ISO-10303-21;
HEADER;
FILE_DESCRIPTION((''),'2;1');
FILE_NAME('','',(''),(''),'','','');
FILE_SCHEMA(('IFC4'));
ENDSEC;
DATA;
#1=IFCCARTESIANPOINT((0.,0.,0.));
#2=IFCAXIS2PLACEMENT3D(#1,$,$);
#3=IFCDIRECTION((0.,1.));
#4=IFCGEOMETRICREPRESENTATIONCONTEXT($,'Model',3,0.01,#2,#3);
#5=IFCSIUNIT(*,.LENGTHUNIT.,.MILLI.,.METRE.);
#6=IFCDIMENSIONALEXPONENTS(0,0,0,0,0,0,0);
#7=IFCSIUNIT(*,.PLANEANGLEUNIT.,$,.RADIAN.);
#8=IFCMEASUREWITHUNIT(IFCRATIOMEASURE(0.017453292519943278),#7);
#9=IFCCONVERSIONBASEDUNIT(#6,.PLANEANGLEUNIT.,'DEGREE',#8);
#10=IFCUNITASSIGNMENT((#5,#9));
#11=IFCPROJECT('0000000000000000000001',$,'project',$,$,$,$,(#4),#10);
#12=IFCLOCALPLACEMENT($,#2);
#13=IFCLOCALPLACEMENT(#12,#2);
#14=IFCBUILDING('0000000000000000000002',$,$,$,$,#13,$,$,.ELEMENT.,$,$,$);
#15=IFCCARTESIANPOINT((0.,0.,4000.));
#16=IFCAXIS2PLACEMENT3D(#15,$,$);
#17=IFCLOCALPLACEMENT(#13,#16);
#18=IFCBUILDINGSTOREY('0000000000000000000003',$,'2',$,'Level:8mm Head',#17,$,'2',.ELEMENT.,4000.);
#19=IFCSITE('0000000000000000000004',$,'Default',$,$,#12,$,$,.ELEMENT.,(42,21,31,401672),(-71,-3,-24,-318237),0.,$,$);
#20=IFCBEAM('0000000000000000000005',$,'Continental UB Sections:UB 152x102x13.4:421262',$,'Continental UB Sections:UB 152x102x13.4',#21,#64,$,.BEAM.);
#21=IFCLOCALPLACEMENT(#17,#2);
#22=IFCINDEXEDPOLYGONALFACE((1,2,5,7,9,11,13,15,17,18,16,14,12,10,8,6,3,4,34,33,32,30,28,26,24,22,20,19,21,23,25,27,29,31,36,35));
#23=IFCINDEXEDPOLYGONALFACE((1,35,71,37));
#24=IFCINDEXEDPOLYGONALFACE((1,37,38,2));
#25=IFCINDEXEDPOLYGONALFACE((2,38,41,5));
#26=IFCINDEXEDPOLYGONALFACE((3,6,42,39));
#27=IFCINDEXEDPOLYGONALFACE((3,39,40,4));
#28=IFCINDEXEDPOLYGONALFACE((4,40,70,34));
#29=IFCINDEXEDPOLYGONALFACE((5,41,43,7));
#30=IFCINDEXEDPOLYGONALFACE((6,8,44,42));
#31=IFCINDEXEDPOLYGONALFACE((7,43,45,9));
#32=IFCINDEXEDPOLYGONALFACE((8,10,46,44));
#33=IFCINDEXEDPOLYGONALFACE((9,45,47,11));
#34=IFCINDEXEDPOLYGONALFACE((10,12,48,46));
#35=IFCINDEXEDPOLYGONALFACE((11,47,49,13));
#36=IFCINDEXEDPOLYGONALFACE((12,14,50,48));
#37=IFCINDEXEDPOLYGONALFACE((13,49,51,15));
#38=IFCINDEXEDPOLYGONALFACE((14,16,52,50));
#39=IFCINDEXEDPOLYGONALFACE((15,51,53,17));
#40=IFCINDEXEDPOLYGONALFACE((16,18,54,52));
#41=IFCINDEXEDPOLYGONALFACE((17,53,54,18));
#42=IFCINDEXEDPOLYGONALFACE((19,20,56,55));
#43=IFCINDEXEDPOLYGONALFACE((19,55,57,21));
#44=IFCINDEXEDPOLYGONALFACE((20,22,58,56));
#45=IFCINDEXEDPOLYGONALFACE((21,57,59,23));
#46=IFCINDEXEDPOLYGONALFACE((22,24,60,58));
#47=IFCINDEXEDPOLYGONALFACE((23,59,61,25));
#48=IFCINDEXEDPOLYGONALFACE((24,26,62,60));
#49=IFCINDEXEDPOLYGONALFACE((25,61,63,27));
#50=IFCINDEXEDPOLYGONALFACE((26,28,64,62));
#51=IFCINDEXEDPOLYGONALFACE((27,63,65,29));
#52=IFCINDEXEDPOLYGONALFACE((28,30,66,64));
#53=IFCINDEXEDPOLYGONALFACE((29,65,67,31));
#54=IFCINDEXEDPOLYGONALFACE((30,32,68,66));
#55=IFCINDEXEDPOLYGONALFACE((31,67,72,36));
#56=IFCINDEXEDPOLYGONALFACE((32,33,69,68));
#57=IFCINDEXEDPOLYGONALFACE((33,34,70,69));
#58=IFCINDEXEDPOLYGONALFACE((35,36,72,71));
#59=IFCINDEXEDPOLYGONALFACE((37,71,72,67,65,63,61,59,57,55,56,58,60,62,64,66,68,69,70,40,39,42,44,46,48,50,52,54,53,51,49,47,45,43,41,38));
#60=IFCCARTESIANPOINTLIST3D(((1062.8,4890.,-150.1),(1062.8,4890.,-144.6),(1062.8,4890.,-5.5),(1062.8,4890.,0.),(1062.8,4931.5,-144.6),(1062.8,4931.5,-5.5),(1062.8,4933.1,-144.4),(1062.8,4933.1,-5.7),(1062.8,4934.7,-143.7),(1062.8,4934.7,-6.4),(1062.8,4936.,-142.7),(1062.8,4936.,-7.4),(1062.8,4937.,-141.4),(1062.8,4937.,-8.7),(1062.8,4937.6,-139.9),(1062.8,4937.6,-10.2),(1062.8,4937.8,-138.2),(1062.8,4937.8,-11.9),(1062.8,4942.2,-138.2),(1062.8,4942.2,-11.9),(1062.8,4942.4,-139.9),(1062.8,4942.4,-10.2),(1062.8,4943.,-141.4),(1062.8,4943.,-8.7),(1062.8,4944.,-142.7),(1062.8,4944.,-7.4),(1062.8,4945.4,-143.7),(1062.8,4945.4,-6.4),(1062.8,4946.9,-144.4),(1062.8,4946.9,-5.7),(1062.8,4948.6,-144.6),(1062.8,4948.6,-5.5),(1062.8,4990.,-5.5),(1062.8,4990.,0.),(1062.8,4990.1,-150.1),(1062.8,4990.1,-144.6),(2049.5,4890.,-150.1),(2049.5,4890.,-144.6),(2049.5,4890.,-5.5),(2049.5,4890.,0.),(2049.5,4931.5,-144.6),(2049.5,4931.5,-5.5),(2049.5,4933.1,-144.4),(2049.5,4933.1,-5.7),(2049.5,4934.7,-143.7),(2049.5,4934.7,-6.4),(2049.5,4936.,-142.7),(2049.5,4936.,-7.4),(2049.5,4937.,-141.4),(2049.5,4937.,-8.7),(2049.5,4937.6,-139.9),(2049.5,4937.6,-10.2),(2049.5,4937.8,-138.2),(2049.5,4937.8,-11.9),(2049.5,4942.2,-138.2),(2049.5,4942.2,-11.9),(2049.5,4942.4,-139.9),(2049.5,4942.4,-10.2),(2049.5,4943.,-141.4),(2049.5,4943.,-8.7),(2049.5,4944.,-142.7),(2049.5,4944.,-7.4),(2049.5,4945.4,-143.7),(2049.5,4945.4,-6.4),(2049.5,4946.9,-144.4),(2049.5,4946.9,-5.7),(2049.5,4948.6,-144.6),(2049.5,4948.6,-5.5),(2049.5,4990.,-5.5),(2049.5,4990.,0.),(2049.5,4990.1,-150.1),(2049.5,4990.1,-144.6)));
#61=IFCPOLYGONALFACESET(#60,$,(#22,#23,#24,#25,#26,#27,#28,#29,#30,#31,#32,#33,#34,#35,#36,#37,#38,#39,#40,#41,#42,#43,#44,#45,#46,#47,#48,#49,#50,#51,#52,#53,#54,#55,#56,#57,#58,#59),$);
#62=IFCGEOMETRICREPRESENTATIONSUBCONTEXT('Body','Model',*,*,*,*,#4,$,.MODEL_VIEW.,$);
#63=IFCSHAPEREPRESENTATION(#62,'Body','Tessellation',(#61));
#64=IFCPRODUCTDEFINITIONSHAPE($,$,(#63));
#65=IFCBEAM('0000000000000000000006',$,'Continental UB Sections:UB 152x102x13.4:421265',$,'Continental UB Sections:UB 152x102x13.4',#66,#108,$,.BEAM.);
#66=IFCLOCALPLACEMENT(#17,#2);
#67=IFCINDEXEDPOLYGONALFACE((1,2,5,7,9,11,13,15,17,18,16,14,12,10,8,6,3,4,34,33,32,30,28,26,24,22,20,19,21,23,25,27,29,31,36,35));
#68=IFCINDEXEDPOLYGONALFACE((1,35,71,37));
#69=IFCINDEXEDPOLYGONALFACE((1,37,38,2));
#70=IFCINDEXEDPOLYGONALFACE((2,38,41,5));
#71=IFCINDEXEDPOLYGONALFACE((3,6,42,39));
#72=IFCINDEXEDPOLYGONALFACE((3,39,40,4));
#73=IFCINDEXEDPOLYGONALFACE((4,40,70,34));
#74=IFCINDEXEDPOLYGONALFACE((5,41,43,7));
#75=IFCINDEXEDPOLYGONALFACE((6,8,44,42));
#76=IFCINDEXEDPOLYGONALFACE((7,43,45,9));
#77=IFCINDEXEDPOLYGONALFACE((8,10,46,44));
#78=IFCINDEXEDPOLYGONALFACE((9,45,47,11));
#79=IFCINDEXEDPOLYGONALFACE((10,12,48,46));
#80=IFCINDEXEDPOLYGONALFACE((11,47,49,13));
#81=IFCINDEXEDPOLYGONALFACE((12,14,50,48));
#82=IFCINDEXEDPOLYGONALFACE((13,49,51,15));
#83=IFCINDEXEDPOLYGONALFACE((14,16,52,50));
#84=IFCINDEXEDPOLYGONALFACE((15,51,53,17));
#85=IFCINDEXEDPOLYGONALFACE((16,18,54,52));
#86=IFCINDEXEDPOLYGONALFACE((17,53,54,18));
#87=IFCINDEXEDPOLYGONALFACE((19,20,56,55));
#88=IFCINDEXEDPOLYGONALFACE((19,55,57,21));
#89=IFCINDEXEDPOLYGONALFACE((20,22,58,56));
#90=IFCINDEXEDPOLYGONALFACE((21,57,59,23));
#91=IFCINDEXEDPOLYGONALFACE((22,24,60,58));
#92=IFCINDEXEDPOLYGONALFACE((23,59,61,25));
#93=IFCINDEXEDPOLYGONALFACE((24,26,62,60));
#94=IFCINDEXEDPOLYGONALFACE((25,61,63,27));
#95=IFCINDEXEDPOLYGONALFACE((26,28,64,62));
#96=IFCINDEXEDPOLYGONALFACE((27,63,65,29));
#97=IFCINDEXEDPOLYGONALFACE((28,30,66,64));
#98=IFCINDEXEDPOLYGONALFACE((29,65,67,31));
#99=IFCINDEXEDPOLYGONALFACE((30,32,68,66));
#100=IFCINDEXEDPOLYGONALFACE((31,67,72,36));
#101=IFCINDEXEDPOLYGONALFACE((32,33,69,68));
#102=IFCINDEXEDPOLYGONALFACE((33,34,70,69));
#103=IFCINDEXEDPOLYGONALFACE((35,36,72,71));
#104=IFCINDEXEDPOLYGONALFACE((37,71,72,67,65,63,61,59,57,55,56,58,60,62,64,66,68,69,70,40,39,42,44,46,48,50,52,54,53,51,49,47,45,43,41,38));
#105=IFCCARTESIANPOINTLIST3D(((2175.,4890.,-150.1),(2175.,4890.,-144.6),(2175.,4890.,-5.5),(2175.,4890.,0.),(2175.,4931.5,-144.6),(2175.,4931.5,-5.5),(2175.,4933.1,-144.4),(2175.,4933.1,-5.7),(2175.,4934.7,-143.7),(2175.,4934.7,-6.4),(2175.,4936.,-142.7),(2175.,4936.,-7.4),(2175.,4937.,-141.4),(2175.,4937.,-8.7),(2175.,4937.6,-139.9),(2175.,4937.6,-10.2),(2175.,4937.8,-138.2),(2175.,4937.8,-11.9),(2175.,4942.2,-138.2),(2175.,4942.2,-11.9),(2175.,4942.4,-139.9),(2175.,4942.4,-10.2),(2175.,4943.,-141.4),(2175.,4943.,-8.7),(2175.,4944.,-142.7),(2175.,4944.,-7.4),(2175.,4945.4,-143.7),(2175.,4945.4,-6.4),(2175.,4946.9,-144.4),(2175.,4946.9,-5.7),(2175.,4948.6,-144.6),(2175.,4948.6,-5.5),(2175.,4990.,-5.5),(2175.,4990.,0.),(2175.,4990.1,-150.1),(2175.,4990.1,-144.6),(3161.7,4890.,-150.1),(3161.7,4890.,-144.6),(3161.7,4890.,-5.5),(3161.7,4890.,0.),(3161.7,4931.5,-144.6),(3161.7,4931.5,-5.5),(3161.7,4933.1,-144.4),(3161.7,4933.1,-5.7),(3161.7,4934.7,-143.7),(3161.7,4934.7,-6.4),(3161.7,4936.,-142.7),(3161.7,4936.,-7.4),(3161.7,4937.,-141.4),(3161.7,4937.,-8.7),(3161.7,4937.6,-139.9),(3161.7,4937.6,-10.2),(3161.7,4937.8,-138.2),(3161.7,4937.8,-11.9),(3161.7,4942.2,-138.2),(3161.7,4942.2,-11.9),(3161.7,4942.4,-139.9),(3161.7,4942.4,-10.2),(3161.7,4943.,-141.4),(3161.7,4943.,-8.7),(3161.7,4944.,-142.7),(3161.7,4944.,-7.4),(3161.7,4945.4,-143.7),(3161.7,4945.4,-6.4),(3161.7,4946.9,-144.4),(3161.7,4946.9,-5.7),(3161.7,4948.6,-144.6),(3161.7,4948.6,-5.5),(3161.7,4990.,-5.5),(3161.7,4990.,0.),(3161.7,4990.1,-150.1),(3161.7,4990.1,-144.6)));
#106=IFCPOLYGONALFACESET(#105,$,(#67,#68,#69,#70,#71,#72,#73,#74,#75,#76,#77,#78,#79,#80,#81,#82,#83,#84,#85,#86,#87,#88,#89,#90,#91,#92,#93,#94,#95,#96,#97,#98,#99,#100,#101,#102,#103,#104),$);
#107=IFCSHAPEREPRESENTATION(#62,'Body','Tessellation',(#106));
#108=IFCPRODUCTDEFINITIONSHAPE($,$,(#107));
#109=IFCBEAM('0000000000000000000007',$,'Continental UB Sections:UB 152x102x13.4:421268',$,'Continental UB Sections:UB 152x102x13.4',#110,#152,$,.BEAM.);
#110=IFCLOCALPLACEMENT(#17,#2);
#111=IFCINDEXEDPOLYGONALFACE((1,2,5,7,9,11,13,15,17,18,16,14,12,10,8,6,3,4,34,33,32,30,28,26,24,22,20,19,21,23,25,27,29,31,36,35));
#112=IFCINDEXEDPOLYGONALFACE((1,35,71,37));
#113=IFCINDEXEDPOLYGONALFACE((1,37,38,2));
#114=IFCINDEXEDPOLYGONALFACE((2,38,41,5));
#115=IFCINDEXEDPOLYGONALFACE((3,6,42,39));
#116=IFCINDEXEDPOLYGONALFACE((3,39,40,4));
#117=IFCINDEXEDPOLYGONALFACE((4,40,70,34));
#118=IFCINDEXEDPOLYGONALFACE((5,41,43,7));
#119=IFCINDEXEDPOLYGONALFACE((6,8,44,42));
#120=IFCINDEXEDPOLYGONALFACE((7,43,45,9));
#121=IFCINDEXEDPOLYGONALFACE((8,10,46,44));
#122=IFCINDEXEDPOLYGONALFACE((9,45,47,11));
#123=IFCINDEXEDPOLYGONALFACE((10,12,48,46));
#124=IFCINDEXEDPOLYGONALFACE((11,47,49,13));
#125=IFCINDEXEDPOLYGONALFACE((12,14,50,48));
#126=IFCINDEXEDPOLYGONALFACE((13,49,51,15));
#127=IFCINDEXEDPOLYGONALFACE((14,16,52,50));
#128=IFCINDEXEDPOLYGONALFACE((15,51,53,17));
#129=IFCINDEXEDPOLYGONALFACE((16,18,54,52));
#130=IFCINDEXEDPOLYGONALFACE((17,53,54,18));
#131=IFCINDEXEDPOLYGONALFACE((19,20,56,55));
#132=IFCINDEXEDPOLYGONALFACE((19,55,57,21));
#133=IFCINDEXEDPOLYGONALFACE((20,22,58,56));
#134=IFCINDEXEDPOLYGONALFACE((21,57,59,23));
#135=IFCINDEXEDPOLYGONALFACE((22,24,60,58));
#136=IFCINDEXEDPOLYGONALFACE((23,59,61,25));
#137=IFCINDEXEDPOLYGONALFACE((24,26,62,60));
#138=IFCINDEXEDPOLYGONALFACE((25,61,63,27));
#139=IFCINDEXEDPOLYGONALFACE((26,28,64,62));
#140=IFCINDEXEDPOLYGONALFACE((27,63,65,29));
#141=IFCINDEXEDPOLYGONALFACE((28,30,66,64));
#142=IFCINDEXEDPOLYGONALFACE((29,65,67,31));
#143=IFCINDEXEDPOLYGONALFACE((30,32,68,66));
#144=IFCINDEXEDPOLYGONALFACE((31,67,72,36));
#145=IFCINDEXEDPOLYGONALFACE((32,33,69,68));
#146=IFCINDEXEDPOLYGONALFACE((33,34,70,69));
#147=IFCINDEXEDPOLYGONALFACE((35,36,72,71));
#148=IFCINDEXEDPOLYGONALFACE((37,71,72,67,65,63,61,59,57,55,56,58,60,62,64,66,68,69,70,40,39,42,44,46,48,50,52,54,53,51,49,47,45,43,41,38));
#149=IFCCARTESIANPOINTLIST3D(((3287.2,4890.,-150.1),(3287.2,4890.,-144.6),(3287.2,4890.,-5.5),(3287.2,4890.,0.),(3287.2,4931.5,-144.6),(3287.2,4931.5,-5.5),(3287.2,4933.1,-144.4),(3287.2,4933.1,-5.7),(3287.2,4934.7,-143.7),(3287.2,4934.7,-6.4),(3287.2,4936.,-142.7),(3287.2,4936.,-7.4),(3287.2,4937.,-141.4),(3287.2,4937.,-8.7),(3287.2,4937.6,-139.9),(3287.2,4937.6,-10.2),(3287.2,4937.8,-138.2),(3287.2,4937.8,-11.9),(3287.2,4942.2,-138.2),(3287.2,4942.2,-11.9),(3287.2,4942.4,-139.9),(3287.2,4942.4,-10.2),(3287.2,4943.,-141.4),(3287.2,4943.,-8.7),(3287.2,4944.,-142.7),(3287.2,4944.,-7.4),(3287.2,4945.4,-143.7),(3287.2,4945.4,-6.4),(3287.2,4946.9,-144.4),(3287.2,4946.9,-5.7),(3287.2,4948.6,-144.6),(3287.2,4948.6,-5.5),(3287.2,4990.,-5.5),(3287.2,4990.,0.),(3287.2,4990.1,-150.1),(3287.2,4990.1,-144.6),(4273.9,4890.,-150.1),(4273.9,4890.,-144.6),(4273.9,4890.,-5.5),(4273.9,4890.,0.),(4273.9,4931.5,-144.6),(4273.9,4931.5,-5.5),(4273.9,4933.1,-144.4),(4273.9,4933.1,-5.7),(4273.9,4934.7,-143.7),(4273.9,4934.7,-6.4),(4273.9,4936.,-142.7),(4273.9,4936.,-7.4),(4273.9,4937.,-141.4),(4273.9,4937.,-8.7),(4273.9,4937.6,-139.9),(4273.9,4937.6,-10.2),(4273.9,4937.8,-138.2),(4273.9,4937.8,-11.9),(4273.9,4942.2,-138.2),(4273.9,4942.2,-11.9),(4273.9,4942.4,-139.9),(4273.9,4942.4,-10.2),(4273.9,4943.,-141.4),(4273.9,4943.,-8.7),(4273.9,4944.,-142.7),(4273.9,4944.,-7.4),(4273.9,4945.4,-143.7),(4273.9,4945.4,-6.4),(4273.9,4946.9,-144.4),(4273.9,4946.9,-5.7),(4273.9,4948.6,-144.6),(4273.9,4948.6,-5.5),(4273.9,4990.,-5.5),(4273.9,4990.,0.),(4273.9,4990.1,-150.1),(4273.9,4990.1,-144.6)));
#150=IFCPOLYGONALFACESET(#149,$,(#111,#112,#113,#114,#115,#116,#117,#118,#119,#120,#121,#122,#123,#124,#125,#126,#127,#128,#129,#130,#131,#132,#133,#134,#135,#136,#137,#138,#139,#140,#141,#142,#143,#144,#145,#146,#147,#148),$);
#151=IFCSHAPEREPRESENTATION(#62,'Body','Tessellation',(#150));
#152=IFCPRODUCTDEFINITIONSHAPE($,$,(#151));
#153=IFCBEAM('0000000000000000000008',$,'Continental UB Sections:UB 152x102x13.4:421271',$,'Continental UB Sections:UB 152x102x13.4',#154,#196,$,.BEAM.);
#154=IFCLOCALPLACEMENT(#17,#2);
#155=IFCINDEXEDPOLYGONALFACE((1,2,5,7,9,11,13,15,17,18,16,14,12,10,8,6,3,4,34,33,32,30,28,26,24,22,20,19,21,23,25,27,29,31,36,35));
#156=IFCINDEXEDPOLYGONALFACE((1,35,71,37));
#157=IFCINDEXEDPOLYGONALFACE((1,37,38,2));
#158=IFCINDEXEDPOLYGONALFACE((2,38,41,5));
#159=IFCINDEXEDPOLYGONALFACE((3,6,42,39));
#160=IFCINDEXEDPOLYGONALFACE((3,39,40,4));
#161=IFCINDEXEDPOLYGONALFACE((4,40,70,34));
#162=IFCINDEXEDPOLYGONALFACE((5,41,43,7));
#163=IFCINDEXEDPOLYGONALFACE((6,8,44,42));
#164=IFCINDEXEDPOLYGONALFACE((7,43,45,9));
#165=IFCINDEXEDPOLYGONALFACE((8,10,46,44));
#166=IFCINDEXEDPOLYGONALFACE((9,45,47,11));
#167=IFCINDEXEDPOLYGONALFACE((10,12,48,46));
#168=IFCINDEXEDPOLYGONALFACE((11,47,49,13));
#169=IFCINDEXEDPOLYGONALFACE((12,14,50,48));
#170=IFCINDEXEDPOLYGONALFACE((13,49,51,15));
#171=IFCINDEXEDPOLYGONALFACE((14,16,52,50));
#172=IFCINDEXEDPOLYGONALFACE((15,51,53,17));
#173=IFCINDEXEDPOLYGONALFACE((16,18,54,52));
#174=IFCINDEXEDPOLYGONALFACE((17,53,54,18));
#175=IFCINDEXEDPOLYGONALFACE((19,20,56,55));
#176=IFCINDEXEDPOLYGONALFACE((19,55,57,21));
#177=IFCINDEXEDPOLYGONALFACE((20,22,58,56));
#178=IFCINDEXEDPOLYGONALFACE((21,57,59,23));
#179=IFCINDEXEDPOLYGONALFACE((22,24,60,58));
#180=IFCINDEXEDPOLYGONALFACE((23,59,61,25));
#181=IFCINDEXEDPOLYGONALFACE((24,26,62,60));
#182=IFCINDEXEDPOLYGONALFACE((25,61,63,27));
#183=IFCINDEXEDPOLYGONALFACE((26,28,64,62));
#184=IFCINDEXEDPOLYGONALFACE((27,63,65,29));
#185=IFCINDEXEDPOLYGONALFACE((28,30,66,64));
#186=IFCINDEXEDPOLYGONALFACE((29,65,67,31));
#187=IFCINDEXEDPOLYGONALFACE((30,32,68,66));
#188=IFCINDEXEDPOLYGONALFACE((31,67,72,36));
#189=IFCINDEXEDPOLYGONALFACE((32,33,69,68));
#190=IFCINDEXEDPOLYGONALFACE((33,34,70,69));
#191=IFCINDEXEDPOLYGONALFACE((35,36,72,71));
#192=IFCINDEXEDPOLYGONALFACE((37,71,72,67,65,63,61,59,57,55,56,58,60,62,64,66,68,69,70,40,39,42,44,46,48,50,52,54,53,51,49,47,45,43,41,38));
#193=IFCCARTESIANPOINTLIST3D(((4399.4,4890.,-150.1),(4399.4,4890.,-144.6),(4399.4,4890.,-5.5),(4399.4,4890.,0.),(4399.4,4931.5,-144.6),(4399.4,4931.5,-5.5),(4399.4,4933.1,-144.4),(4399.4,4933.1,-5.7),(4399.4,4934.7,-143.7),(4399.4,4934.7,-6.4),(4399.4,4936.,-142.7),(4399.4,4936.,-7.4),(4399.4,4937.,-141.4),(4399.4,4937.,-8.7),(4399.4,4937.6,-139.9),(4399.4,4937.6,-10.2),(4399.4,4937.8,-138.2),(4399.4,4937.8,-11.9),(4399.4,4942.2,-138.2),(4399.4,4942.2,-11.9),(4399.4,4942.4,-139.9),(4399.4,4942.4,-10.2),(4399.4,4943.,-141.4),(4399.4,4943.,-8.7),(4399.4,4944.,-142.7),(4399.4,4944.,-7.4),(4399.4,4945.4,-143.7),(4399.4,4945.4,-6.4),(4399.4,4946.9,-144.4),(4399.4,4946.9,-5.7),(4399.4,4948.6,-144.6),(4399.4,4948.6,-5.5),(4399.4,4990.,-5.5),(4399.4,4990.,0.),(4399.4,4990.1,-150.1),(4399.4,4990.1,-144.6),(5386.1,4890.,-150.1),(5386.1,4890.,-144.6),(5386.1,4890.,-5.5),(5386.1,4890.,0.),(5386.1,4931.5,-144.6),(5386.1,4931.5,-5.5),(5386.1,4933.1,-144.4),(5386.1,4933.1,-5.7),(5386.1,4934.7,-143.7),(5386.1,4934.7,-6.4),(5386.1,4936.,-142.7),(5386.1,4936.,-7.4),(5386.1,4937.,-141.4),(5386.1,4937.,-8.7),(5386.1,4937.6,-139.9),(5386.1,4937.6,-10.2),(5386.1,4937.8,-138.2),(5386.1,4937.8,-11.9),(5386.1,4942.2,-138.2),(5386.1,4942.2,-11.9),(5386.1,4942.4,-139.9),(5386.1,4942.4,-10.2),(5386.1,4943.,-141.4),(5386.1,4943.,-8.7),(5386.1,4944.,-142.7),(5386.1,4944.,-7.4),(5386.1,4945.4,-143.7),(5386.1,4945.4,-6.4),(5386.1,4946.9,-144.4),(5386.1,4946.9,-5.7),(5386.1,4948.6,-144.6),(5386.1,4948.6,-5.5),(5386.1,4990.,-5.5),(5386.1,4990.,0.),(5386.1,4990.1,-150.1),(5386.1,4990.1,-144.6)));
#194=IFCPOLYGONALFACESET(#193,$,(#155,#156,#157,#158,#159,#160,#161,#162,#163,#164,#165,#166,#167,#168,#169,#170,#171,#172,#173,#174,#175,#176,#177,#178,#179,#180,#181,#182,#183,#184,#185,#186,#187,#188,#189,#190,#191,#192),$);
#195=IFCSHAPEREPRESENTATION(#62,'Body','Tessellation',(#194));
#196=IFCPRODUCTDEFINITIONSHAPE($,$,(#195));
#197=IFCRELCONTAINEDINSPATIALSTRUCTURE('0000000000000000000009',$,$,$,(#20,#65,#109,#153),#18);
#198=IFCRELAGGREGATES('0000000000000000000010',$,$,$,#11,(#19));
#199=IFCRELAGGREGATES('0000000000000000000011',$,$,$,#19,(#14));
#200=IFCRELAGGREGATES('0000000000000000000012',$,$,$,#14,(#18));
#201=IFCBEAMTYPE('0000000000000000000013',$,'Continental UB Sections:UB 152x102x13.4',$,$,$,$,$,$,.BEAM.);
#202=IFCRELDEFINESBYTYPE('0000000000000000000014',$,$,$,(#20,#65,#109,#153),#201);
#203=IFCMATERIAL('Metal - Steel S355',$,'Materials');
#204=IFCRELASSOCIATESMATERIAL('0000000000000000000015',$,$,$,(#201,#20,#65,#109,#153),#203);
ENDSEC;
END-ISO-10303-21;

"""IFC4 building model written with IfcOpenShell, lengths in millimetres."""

from ifc_helpers import new_model, entity, si_unit, converted_unit, direction, frame, origin, place, context, subcontext, project, spatial, line, arc, indexed_curve, outline, extrude, source, transform, mapped, material, type_object, type_shapes, element, save


model = new_model("IFC4")

# Units and contexts
model_context = context("Model", 3, precision=0.01, world=origin(), true_north=direction((0.0, 1.0)))
body_context = subcontext(model_context, "Body", "Model", "MODEL_VIEW")
ifc_project = project(units=[si_unit("LENGTHUNIT", "METRE", prefix="MILLI"), converted_unit("PLANEANGLEUNIT", "DEGREE", entity("IfcRatioMeasure", 0.017453292519943278), si_unit("PLANEANGLEUNIT", "RADIAN"), dimensions=[0, 0, 0, 0, 0, 0, 0])], contexts=[model_context])

# Site, building, storey
site_placement = place(None, origin())
site = spatial("IfcSite", under=ifc_project, at=site_placement, Name="Default", CompositionType="ELEMENT", RefLatitude=(42, 21, 31, 401672), RefLongitude=(-71, -3, -24, -318237), RefElevation=0.0)
building_placement = place(site_placement, origin())
building = spatial("IfcBuilding", under=site, at=building_placement, CompositionType="ELEMENT")
storey_placement = place(building_placement, frame((0.0, 0.0, 4000.0)))
storey = spatial("IfcBuildingStorey", under=building, at=storey_placement, Name="2", ObjectType="Level:8mm Head", LongName="2", CompositionType="ELEMENT", Elevation=4000.0)

# Beams
ifc_material = material(Name="Metal - Steel S355", Category="Materials")
beam_type_1 = type_object("IfcBeamType", Name="Continental UB Sections:UB 152x102x13.4", PredefinedType="BEAM", material=ifc_material)
shared_shape_1 = source(origin(), body_context, "Body", "SweptSolid", [
    extrude(outline(indexed_curve([(-75.0, -50.1), (-69.6, -50.1), (-69.6, -8.5), (-67.7, -4.0), (-63.2, -2.1), (63.1, -2.1), (67.7, -4.0), (69.5, -8.5), (69.5, -50.1), (75.1, -50.1), (75.1, 50.1), (69.5, 50.1), (69.5, 8.6), (67.7, 4.0), (63.1, 2.2), (-63.2, 2.2), (-67.7, 4.0), (-69.6, 8.6), (-69.6, 50.0), (-75.0, 50.0)], segments=[line(1, 2, 3), arc(3, 4, 5), line(5, 6), arc(6, 7, 8), line(8, 9, 10, 11, 12, 13), arc(13, 14, 15), line(15, 16), arc(16, 17, 18), line(18, 19, 20, 1)], self_intersect=False)), frame((-493.3, 0.0, 0.0), z_axis=(1.0, 0.0, 0.0), x_axis=(0.0, 0.0, -1.0)), (0.0, 0.0, 1.0), 986.7),
])
type_shapes(beam_type_1, [shared_shape_1])
for number, where, name in (
    (1, (1556.1, 4940.0, -75.1), "Continental UB Sections:UB 152x102x13.4:421262"),
    (2, (2668.3, 4940.0, -75.1), "Continental UB Sections:UB 152x102x13.4:421265"),
    (3, (3780.6, 4940.0, -75.1), "Continental UB Sections:UB 152x102x13.4:421268"),
    (4, (4892.8, 4940.0, -75.1), "Continental UB Sections:UB 152x102x13.4:421271"),
):
    element("IfcBeam", number, at=place(storey_placement, frame(where)), inside=storey, type_object=beam_type_1, material=ifc_material, Name=name, ObjectType="Continental UB Sections:UB 152x102x13.4", PredefinedType="BEAM", context=body_context, shape_type="MappedRepresentation", body=[
        mapped(shared_shape_1, transform((0.0, 0.0, 0.0), scale=1.0)),
    ])

save(model, "model.ifc")
